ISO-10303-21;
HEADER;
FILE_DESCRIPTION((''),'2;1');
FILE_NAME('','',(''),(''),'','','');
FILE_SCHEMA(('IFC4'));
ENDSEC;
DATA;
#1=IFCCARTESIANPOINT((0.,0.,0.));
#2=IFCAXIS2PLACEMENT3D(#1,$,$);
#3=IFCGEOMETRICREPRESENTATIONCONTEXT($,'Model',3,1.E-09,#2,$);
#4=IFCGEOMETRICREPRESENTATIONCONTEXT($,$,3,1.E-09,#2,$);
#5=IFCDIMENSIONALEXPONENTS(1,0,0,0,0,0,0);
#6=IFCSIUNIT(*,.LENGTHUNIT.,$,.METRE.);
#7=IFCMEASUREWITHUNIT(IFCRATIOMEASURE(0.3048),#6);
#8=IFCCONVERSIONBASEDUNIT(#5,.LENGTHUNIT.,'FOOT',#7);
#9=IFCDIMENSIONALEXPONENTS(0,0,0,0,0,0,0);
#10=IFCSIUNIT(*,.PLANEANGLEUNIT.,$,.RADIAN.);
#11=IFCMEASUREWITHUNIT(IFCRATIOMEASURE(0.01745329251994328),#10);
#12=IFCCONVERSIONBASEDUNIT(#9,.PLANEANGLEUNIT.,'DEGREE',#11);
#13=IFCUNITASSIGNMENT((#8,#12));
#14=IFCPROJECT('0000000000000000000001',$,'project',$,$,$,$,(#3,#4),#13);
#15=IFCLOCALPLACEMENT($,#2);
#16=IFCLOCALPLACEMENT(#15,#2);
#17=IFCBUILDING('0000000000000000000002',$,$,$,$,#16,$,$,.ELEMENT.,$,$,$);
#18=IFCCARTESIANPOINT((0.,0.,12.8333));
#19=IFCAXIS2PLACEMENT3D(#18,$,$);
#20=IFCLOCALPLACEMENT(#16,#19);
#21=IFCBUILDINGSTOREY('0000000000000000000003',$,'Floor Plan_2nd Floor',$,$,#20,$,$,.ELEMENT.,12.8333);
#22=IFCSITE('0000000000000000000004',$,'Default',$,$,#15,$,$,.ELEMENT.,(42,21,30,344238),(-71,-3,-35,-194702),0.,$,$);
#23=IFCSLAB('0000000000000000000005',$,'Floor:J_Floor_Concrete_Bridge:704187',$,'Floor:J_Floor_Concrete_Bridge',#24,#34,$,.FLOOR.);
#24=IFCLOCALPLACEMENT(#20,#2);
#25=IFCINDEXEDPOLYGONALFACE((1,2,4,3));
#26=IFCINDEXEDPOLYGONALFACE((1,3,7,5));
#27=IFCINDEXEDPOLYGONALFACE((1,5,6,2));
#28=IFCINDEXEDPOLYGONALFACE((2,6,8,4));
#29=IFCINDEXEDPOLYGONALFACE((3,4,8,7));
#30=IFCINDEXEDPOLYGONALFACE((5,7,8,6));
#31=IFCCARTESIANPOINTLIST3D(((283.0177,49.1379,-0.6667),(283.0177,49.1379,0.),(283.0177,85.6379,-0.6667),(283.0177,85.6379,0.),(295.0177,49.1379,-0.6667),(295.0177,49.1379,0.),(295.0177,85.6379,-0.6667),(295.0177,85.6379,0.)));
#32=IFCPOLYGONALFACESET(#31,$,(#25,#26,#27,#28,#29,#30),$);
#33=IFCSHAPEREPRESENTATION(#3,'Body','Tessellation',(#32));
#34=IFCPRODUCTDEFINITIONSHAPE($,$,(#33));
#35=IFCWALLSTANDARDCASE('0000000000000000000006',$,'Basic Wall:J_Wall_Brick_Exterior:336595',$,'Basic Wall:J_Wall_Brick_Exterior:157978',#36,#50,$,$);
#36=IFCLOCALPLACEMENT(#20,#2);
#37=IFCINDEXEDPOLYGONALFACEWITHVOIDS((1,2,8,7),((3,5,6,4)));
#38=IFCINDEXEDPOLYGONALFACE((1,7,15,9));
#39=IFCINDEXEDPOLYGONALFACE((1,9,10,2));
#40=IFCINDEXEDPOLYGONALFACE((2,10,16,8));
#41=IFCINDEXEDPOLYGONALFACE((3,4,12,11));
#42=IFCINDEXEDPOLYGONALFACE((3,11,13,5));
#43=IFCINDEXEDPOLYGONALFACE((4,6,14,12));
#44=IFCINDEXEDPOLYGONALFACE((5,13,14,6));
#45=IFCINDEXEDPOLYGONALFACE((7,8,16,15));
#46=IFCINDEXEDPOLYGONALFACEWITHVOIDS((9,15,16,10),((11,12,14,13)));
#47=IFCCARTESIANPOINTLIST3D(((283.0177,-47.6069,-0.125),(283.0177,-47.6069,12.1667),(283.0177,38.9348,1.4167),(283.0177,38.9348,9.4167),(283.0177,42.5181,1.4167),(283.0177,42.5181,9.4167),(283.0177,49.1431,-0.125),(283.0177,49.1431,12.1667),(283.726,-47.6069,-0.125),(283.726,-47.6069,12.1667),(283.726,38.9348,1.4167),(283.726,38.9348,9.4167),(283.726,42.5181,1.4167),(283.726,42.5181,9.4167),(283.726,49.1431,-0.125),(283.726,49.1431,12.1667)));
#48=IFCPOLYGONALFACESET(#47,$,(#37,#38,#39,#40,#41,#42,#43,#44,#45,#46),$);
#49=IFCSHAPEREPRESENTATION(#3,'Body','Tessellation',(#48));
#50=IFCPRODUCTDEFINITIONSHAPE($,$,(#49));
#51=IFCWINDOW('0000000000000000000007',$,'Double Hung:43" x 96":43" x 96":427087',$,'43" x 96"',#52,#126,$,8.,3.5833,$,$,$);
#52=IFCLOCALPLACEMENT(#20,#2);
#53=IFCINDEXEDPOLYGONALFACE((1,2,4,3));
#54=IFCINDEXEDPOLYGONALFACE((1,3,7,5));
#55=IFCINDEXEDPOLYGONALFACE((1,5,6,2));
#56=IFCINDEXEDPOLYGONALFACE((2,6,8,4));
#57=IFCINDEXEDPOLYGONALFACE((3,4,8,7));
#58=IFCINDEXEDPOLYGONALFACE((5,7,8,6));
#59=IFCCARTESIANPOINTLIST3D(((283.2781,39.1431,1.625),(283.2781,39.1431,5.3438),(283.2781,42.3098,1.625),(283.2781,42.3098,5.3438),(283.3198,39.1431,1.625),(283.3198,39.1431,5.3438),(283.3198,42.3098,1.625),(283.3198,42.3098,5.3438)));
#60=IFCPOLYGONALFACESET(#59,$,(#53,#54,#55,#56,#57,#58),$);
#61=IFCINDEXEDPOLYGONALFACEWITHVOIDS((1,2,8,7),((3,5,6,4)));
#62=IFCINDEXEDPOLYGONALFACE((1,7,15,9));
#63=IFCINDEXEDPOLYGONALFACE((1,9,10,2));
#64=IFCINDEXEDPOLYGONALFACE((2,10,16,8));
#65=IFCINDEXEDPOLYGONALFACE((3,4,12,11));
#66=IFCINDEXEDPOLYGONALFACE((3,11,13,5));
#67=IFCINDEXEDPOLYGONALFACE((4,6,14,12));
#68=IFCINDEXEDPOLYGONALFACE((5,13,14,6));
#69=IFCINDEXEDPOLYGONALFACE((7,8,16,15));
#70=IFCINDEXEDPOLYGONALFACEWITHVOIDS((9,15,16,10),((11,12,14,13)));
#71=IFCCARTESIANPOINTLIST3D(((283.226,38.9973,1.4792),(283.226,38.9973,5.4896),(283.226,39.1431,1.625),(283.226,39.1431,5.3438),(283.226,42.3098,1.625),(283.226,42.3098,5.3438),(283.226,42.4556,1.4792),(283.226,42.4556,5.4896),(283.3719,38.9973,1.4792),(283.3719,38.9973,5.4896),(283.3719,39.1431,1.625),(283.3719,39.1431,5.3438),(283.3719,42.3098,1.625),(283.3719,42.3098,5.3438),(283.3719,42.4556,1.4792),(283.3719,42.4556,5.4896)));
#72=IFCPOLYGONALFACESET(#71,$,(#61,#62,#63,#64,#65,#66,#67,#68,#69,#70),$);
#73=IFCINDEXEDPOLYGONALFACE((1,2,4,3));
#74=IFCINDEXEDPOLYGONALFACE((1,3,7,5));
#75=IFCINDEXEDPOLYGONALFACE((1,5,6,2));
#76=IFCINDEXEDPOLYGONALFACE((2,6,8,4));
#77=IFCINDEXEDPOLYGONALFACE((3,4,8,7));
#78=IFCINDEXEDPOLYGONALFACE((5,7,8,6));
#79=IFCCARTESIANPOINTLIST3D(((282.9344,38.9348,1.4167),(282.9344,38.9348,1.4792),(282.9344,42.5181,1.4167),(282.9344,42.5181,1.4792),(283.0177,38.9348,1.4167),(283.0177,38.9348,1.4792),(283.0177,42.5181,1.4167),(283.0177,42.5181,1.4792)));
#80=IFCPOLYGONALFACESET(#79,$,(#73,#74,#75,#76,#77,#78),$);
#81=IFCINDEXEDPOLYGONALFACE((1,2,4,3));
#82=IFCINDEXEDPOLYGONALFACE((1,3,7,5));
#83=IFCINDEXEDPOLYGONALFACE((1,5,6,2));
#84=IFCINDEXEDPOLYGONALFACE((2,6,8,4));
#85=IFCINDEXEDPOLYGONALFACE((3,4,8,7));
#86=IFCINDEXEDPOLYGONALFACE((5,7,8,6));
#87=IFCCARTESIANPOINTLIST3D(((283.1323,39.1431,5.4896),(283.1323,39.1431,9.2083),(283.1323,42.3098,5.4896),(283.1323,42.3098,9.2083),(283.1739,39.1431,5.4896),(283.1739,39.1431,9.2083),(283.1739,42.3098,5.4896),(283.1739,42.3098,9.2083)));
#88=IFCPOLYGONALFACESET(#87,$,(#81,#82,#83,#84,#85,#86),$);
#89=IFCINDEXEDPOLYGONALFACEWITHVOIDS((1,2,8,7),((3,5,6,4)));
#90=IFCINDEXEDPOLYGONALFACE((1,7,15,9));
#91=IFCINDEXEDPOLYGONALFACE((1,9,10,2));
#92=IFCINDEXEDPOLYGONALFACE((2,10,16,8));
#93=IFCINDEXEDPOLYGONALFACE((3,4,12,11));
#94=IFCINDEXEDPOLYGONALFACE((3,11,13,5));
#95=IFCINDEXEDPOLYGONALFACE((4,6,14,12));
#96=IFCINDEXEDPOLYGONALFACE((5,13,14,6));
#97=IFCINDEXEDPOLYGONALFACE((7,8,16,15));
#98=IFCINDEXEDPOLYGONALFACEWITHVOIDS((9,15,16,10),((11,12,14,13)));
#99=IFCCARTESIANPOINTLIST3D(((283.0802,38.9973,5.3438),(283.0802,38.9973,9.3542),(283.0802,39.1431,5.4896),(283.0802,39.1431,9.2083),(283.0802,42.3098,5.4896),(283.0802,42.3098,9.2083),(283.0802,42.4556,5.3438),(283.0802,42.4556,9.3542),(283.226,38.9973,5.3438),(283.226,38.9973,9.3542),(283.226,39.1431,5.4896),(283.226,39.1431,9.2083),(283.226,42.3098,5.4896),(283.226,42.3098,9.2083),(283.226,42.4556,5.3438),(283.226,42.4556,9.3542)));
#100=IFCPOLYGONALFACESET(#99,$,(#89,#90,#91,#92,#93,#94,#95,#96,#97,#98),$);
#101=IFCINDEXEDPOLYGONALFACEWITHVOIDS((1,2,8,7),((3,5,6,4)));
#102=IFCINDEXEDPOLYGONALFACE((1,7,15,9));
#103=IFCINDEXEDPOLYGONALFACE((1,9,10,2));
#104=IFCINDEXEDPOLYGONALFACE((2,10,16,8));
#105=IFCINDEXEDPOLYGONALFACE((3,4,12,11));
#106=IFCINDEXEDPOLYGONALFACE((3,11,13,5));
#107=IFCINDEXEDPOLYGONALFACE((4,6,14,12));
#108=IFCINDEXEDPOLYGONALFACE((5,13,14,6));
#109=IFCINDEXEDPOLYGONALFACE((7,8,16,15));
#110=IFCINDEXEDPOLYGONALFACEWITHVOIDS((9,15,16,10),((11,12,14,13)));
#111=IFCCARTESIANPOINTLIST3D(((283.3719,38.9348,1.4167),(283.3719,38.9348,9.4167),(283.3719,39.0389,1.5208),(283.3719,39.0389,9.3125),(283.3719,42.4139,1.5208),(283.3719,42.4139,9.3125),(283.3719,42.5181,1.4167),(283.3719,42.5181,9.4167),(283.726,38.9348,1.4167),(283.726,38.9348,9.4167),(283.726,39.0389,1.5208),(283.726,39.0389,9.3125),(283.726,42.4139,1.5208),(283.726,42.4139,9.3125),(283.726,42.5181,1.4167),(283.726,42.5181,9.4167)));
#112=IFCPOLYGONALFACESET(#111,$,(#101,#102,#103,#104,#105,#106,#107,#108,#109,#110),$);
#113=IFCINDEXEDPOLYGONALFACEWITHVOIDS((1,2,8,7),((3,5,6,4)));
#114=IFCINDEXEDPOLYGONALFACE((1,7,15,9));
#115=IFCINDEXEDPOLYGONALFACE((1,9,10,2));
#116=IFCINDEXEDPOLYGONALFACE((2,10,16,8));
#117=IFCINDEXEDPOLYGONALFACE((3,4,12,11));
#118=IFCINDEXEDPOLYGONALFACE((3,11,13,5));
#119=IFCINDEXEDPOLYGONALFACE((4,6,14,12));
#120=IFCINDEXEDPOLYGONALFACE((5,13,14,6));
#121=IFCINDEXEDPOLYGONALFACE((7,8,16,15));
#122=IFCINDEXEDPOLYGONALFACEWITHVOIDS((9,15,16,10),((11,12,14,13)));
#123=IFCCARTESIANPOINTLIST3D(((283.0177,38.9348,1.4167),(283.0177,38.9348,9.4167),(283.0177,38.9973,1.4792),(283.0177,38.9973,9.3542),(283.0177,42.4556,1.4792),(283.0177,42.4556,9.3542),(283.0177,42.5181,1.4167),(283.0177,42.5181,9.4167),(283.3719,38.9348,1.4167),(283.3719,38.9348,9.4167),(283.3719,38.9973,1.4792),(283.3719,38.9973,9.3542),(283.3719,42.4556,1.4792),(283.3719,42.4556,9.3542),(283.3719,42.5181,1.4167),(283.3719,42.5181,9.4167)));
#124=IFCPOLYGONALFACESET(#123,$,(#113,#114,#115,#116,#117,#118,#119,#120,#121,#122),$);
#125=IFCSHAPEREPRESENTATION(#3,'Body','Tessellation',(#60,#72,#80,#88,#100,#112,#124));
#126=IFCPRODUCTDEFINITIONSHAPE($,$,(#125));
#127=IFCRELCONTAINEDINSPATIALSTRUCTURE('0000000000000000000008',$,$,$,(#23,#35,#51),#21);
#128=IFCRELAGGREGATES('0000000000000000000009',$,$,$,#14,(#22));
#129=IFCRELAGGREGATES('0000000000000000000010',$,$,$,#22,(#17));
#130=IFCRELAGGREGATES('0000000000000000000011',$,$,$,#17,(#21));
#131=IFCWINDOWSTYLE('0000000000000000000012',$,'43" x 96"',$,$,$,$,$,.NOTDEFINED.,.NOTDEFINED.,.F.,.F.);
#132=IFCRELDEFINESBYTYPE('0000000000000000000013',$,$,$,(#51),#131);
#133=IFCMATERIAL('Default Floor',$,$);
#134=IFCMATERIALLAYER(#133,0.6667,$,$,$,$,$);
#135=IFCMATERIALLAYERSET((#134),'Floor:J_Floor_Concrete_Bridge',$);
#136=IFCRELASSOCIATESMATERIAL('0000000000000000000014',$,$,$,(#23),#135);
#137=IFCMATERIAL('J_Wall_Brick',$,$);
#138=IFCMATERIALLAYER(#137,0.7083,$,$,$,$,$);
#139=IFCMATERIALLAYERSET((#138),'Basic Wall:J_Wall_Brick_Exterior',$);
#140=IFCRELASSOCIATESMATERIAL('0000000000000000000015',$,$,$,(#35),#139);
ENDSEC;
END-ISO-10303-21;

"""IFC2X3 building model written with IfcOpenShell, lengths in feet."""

from ifc_helpers import new_model, entity, si_unit, converted_unit, frame, frame_2d, origin, origin_2d_with_axis, place, context, project, spatial, polyline, rectangle, outline, extrude, source, transform, mapped, material, layer, layer_set, layer_usage, type_object, type_shapes, element, fill, save


model = new_model("IFC2X3")

# Units and contexts
model_context = context("Model", 3, precision=1e-09, world=origin())
context_of_model = context(None, 3, precision=1e-09, world=origin())
ifc_project = project(units=[converted_unit("LENGTHUNIT", "FOOT", entity("IfcRatioMeasure", 0.3048), si_unit("LENGTHUNIT", "METRE"), dimensions=[1, 0, 0, 0, 0, 0, 0]), converted_unit("PLANEANGLEUNIT", "DEGREE", entity("IfcRatioMeasure", 0.01745329251994328), si_unit("PLANEANGLEUNIT", "RADIAN"), dimensions=[0, 0, 0, 0, 0, 0, 0])], contexts=[model_context, context_of_model])

# Site, building, storey
site_placement = place(None, origin())
site = spatial("IfcSite", under=ifc_project, at=site_placement, Name="Default", CompositionType="ELEMENT", RefLatitude=(42, 21, 30, 344238), RefLongitude=(-71, -3, -35, -194702), RefElevation=0.0)
building_placement = place(site_placement, origin())
building = spatial("IfcBuilding", under=site, at=building_placement, CompositionType="ELEMENT")
storey_placement = place(building_placement, frame((0.0, 0.0, 12.8333)))
storey = spatial("IfcBuildingStorey", under=building, at=storey_placement, Name="Floor Plan_2nd Floor", CompositionType="ELEMENT", Elevation=12.8333)

# Slab
ifc_material_1 = material(Name="Default Floor")
ifc_layer_1 = layer(ifc_material_1, 0.6667)
ifc_layer_set_1 = layer_set([ifc_layer_1], Name="Floor:J_Floor_Concrete_Bridge")
ifc_layer_usage_1 = layer_usage(ifc_layer_set_1, "AXIS3", "POSITIVE", 0.0)
slab_placement = place(storey_placement, frame((283.0177, 49.1379, -0.6667)))
element("IfcSlab", 1, at=slab_placement, inside=storey, material=ifc_layer_usage_1, Name="Floor:J_Floor_Concrete_Bridge:704187", ObjectType="Floor:J_Floor_Concrete_Bridge", PredefinedType="FLOOR", context=model_context, shape_type="SweptSolid", body=[
    extrude(rectangle(XDim=12.0, YDim=36.5, at=frame_2d((0.0, 0.0), x_axis=(-1.0, 0.0))), frame((6.0, 18.25, 0.6667), z_axis=(0.0, 0.0, -1.0), x_axis=(-1.0, 0.0, 0.0)), (0.0, 0.0, 1.0), 0.6667),
])

# Wall, opening, window
ifc_material_2 = material(Name="J_Wall_Brick")
ifc_layer_2 = layer(ifc_material_2, 0.7083)
ifc_layer_set_2 = layer_set([ifc_layer_2], Name="Basic Wall:J_Wall_Brick_Exterior")
ifc_layer_usage_2 = layer_usage(ifc_layer_set_2, "AXIS2", "NEGATIVE", 0.3542)
wall_1_placement = place(storey_placement, frame((283.3719, -47.6069, -0.125), z_axis=(0.0, 0.0, 1.0), x_axis=(0.0, 1.0, 0.0)))
wall_1 = element("IfcWallStandardCase", 2, at=wall_1_placement, inside=storey, material=ifc_layer_usage_2, Name="Basic Wall:J_Wall_Brick_Exterior:336595", ObjectType="Basic Wall:J_Wall_Brick_Exterior:157978", context=model_context, shape_type="SweptSolid", body=[
    extrude(rectangle(XDim=96.75, YDim=0.7083, at=frame_2d((48.375, 0.0), x_axis=(-1.0, 0.0))), origin(), (0.0, 0.0, 1.0), 12.2917),
])
opening_1_placement = place(wall_1_placement, frame((86.5417, -0.3542, 1.5417)))
opening_1 = element("IfcOpeningElement", 3, at=opening_1_placement, cuts=wall_1, ObjectType="Opening", context=model_context, shape_type="SweptSolid", body=[
    extrude(rectangle(XDim=8.0, YDim=3.5833, at=frame_2d((4.0, 1.7917), x_axis=(-1.0, 0.0))), frame((0.0, 0.0, 0.0), z_axis=(0.0, 1.0, 0.0), x_axis=(0.0, 0.0, 1.0)), (0.0, 0.0, 1.0), 0.7083),
])
window_style = type_object("IfcWindowStyle", Name="43\" x 96\"", ConstructionType="NOTDEFINED", OperationType="NOTDEFINED", ParameterTakesPrecedence=False, Sizeable=False)
shared_shape = source(origin(), model_context, "Body", "SweptSolid", [
    extrude(rectangle(XDim=0.0417, YDim=3.1667, at=origin_2d_with_axis()), frame((1.7917, 0.4271, 0.2083), z_axis=(0.0, 0.0, 1.0), x_axis=(0.0, -1.0, 0.0)), (0.0, 0.0, 1.0), 3.7187),
    extrude(outline(polyline([(-1.7292, -2.0052), (1.7292, -2.0052), (1.7292, 2.0052), (-1.7292, 2.0052), (-1.7292, -2.0052)]), holes=[polyline([(-1.5833, -1.8594), (-1.5833, 1.8594), (1.5833, 1.8594), (1.5833, -1.8594), (-1.5833, -1.8594)])]), frame((1.7917, 0.3542, 2.0677), z_axis=(0.0, 1.0, 0.0), x_axis=(1.0, 0.0, 0.0)), (0.0, 0.0, 1.0), 0.1458),
    extrude(rectangle(XDim=0.0833, YDim=3.5833, at=origin_2d_with_axis()), frame((1.7917, 0.75, 0.0), z_axis=(0.0, 0.0, 1.0), x_axis=(0.0, -1.0, 0.0)), (0.0, 0.0, 1.0), 0.0625),
    extrude(rectangle(XDim=0.0417, YDim=3.1667, at=origin_2d_with_axis()), frame((1.7917, 0.5729, 4.0729), z_axis=(0.0, 0.0, 1.0), x_axis=(0.0, 1.0, 0.0)), (0.0, 0.0, 1.0), 3.7187),
    extrude(outline(polyline([(-1.7292, -2.0052), (1.7292, -2.0052), (1.7292, 2.0052), (-1.7292, 2.0052), (-1.7292, -2.0052)]), holes=[polyline([(-1.5833, -1.8594), (-1.5833, 1.8594), (1.5833, 1.8594), (1.5833, -1.8594), (-1.5833, -1.8594)])]), frame((1.7917, 0.5, 5.9323), z_axis=(0.0, 1.0, 0.0), x_axis=(1.0, 0.0, 0.0)), (0.0, 0.0, 1.0), 0.1458),
    extrude(outline(polyline([(-1.7917, -4.0), (1.7917, -4.0), (1.7917, 4.0), (-1.7917, 4.0), (-1.7917, -4.0)]), holes=[polyline([(-1.6875, -3.8958), (-1.6875, 3.8958), (1.6875, 3.8958), (1.6875, -3.8958), (-1.6875, -3.8958)])]), frame((1.7917, 0.0, 4.0), z_axis=(0.0, 1.0, 0.0), x_axis=(1.0, 0.0, 0.0)), (0.0, 0.0, 1.0), 0.3542),
    extrude(outline(polyline([(-4.0, -1.7917), (4.0, -1.7917), (4.0, 1.7917), (-4.0, 1.7917), (-4.0, -1.7917)]), holes=[polyline([(-3.9375, -1.7292), (-3.9375, 1.7292), (3.9375, 1.7292), (3.9375, -1.7292), (-3.9375, -1.7292)])]), frame((1.7917, 0.3542, 4.0), z_axis=(0.0, 1.0, 0.0), x_axis=(0.0, 0.0, -1.0)), (0.0, 0.0, 1.0), 0.3542),
])
type_shapes(window_style, [shared_shape])
window_1_placement = place(opening_1_placement, origin())
window_1 = element("IfcWindow", 4, at=window_1_placement, inside=storey, type_object=window_style, Name="Double Hung:43\" x 96\":43\" x 96\":427087", ObjectType="43\" x 96\"", OverallHeight=8.0, OverallWidth=3.5833, context=model_context, shape_type="MappedRepresentation", body=[
    mapped(shared_shape, transform((0.0, 0.0, 0.0), scale=1.0)),
])
fill(opening_1, window_1)

save(model, "model.ifc")
